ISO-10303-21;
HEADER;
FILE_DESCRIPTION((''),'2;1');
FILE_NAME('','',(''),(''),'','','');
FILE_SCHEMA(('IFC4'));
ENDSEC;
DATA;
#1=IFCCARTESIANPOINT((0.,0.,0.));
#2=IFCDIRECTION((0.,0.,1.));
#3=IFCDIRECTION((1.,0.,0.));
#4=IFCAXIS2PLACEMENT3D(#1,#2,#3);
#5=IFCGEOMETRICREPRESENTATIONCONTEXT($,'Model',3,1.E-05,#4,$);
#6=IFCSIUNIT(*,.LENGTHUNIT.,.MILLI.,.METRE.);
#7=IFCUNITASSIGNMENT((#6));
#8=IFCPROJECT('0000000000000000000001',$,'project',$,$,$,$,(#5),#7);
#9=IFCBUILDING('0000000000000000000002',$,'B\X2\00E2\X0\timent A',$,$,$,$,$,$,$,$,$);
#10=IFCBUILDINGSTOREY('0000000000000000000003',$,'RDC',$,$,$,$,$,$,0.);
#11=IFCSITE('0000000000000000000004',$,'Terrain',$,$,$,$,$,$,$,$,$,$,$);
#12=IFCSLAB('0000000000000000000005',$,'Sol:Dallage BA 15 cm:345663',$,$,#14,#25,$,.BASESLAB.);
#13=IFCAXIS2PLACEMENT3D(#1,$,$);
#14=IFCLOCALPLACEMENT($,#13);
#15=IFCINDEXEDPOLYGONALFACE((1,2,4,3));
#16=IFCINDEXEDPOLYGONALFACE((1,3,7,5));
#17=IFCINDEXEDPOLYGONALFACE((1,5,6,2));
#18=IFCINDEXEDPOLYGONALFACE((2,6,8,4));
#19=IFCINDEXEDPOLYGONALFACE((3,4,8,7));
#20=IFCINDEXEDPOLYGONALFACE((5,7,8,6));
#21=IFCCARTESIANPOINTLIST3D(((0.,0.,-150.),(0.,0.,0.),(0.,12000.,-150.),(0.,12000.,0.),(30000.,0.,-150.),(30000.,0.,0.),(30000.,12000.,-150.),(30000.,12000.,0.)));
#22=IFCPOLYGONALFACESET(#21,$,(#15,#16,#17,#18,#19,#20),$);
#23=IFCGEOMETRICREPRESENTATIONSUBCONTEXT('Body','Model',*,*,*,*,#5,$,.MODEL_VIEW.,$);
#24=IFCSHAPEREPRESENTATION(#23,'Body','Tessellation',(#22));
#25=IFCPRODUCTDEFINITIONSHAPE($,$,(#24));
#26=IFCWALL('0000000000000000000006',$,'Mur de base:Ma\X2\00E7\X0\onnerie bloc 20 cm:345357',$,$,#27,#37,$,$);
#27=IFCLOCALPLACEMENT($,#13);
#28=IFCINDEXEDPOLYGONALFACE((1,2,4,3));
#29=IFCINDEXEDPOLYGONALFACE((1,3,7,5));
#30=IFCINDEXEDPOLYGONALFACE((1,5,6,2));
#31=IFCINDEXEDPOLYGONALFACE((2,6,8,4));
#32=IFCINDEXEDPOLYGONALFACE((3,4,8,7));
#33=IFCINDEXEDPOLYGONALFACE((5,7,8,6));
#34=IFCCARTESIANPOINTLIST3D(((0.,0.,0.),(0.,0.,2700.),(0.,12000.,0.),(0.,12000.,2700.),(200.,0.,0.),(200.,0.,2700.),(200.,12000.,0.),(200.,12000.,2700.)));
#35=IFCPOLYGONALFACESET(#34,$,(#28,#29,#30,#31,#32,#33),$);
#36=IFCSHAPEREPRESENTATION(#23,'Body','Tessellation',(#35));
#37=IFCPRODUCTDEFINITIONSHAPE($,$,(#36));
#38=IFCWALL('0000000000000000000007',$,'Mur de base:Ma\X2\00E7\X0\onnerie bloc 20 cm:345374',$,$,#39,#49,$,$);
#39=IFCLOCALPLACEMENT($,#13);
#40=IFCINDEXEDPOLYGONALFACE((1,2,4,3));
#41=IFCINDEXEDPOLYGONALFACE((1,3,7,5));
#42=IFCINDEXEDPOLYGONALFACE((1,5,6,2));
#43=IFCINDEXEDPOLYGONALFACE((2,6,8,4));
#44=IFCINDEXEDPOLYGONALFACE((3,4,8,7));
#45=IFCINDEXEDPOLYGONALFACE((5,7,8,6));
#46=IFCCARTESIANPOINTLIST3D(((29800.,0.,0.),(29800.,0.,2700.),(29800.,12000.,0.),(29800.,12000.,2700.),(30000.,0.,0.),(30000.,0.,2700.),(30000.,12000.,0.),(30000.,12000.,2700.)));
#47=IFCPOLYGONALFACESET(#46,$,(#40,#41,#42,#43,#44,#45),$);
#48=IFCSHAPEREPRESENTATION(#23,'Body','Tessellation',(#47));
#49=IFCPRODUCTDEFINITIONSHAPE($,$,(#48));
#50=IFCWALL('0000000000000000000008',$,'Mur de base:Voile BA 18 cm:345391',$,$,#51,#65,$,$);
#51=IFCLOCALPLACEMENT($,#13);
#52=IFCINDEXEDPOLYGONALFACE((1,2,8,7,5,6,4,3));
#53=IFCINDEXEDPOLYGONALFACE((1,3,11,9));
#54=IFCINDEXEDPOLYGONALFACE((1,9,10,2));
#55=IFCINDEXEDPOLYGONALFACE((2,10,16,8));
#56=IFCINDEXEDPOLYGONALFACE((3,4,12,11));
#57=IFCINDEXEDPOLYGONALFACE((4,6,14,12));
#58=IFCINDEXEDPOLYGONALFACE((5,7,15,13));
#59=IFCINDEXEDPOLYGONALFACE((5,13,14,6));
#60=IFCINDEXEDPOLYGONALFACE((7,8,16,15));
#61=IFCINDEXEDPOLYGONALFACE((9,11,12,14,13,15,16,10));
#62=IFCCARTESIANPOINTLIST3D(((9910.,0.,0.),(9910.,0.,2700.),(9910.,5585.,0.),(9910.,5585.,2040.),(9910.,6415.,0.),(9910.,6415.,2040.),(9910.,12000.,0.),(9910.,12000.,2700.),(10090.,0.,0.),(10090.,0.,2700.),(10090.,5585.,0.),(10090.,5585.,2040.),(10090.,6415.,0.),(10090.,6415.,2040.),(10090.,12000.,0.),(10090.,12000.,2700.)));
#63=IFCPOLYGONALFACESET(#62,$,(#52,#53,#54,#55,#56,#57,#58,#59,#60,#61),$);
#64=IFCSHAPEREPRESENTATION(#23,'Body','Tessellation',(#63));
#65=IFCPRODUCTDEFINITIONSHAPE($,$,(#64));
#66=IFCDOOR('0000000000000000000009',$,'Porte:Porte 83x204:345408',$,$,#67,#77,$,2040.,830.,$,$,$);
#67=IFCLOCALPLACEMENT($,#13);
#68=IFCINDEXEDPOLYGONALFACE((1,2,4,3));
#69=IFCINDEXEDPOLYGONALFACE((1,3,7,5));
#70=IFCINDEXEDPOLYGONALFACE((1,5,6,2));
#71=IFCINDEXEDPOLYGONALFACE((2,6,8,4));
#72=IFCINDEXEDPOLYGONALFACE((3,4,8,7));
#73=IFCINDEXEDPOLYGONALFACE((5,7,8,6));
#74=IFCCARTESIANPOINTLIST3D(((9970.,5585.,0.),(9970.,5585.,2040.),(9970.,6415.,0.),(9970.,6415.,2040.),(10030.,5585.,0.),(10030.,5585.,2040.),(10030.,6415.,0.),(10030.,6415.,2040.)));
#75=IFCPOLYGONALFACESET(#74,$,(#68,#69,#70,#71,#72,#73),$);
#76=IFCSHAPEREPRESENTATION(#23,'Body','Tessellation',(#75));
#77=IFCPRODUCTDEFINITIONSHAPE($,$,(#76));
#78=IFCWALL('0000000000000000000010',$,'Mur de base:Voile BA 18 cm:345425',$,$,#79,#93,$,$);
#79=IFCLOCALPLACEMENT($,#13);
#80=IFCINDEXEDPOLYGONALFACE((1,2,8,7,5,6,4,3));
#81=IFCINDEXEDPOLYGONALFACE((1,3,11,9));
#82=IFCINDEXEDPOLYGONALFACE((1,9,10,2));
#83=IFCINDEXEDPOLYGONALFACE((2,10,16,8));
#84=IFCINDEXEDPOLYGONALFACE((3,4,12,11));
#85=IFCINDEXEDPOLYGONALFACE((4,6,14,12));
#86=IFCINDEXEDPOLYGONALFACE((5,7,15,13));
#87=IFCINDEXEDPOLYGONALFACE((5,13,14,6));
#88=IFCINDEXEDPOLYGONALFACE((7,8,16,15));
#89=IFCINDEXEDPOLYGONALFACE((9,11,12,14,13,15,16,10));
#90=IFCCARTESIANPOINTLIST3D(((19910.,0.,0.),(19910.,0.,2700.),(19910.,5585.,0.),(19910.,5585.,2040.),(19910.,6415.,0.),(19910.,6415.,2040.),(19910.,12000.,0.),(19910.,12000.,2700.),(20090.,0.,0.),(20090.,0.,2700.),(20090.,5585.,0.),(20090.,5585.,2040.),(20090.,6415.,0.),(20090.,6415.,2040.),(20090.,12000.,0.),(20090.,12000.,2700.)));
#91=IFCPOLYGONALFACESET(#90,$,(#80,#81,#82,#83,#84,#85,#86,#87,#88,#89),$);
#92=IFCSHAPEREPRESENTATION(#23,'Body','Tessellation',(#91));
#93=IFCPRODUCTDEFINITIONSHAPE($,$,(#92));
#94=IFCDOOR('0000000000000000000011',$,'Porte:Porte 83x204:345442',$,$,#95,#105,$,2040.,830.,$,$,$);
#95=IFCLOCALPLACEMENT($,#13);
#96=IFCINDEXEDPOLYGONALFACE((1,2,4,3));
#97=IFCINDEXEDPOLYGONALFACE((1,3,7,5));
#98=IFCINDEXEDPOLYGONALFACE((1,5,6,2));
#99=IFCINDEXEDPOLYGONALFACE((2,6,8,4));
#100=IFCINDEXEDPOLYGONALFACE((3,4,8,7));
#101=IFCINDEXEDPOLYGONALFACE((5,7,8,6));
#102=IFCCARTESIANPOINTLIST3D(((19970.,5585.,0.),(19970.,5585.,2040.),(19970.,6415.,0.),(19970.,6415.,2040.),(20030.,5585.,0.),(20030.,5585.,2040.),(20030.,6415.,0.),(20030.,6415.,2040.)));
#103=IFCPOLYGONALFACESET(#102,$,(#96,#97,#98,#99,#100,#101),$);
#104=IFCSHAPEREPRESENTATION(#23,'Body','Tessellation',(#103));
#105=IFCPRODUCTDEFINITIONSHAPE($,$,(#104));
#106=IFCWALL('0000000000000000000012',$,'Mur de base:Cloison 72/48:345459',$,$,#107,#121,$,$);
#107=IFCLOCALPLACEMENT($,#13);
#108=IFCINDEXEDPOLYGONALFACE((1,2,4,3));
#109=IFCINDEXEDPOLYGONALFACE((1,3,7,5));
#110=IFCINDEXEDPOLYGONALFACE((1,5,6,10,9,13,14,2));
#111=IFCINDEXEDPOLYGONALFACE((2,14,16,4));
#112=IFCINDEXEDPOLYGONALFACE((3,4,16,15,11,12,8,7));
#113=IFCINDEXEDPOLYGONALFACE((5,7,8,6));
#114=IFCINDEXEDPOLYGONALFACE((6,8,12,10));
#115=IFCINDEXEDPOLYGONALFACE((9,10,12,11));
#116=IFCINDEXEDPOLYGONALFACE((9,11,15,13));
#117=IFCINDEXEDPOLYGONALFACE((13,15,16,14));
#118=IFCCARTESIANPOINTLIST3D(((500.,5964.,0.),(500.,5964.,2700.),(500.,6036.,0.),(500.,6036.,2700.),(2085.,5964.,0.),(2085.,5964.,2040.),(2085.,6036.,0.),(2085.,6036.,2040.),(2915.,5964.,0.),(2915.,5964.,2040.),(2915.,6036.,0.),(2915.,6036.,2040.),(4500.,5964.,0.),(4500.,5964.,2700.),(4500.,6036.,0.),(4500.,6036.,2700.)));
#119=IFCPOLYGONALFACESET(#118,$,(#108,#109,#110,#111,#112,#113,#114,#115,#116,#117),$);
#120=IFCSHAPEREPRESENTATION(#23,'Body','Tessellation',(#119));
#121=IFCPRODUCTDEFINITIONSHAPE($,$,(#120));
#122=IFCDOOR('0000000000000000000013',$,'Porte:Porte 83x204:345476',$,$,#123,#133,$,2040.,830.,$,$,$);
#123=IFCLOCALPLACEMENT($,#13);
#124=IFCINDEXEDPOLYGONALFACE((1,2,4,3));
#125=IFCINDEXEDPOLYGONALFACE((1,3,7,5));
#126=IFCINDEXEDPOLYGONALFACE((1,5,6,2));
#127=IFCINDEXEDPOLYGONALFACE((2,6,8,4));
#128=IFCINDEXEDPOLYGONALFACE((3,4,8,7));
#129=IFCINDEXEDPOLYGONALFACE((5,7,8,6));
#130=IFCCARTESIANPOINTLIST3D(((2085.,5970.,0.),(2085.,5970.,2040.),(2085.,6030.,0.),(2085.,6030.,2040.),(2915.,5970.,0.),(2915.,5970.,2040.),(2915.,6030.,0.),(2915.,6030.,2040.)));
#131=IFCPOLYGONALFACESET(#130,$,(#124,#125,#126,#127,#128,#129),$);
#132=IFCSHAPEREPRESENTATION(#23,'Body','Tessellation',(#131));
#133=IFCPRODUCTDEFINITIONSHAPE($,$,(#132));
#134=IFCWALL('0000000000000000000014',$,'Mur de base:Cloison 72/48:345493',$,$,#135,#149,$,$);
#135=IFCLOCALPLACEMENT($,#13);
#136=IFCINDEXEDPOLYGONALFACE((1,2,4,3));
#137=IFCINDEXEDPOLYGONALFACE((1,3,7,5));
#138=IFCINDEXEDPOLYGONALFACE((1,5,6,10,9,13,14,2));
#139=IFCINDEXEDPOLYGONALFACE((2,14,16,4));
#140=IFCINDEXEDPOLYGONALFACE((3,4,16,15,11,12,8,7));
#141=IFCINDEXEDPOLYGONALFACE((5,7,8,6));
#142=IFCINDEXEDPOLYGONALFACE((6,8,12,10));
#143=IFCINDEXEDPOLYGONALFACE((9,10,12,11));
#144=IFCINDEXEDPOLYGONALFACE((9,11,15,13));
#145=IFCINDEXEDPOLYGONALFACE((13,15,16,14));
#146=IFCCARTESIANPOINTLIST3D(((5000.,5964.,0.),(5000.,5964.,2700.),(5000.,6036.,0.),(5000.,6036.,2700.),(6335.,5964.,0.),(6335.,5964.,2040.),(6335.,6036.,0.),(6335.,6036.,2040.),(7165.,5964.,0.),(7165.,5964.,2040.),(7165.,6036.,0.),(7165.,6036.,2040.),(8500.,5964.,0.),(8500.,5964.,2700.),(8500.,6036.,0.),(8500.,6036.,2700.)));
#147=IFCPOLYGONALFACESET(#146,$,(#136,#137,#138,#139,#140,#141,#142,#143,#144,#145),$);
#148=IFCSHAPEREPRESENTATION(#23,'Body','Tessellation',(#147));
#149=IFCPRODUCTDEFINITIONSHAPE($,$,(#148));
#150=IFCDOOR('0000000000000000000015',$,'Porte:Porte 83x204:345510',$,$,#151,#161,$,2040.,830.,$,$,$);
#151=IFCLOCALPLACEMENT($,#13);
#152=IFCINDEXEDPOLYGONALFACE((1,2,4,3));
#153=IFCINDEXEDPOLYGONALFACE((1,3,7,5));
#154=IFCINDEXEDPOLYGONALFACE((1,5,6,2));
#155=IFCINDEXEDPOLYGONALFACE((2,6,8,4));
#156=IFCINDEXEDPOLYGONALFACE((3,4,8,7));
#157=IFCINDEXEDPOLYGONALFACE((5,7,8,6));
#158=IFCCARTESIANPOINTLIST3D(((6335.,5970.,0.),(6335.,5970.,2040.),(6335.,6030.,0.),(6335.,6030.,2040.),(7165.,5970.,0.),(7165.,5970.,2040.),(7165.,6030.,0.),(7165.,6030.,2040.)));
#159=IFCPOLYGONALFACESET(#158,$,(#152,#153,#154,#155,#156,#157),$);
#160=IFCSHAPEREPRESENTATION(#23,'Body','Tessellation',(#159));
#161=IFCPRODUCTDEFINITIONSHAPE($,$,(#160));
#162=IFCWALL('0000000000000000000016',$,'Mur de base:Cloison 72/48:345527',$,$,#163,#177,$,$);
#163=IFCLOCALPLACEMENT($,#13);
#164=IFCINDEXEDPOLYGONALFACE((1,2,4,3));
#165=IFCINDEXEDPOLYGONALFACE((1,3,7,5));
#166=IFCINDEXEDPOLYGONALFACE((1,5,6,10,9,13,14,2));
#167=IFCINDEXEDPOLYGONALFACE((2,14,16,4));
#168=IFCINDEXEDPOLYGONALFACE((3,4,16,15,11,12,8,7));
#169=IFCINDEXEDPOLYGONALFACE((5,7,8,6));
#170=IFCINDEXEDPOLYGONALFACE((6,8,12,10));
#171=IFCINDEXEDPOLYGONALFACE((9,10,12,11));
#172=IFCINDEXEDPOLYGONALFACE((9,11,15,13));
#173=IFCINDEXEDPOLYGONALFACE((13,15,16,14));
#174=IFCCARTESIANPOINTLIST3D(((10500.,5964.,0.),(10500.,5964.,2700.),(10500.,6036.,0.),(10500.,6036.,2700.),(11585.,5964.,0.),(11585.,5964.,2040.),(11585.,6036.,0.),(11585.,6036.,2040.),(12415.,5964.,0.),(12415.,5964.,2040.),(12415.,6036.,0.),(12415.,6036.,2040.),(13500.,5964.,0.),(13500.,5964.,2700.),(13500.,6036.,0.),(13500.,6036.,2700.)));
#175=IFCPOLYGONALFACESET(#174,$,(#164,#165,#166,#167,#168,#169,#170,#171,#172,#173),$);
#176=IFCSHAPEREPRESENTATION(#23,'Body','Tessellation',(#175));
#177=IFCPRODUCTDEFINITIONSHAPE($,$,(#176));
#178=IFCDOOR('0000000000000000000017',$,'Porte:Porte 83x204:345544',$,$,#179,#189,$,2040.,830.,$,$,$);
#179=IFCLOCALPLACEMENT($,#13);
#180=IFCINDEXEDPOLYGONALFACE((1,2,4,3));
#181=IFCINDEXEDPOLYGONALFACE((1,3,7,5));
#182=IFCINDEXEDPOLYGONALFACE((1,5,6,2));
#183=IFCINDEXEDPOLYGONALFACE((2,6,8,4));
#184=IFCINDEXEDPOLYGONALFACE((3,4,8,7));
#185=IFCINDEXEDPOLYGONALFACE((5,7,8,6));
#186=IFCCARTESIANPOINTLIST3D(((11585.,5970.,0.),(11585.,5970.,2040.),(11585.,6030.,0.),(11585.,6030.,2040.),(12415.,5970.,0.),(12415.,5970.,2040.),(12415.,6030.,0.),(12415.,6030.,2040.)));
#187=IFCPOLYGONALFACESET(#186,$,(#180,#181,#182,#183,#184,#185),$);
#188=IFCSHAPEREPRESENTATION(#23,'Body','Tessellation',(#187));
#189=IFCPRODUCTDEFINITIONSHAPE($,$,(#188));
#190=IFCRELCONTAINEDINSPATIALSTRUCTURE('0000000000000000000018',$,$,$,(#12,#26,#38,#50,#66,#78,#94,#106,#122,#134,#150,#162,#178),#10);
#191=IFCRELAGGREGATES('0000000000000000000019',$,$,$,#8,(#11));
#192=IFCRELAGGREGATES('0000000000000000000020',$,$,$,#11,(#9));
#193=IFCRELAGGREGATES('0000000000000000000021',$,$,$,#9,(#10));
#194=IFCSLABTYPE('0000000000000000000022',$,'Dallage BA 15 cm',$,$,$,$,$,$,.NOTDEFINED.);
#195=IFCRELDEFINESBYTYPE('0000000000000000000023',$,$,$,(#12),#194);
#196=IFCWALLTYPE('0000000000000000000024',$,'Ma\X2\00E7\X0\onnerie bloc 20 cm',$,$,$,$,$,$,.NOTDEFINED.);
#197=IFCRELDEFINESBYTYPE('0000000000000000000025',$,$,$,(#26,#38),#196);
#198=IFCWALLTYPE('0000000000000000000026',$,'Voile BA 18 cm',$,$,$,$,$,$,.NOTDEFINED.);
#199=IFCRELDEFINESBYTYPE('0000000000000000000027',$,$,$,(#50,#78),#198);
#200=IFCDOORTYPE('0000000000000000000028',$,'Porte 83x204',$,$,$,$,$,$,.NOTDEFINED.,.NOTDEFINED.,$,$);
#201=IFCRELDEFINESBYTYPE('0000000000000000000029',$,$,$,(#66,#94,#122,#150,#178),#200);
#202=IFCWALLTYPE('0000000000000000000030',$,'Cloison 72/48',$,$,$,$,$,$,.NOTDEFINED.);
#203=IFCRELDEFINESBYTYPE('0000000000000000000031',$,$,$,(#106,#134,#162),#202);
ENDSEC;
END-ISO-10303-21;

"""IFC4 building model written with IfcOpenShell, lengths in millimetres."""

from ifc_helpers import new_model, si_unit, frame, frame_2d, origin_with_axes, place, context, subcontext, project, spatial, rectangle, extrude, type_object, element, fill, save


model = new_model("IFC4")

# Units and contexts
model_context = context("Model", 3, precision=1e-05, world=origin_with_axes())
body_context = subcontext(model_context, "Body", "Model", "MODEL_VIEW")
ifc_project = project(units=[si_unit("LENGTHUNIT", "METRE", prefix="MILLI")], contexts=[model_context])

# Site, building, storey
site = spatial("IfcSite", under=ifc_project, Name="Terrain")
building = spatial("IfcBuilding", under=site, Name="Bâtiment A")
storey = spatial("IfcBuildingStorey", under=building, Name="RDC", Elevation=0.0)

# Slab
slab_type = type_object("IfcSlabType", Name="Dallage BA 15 cm", PredefinedType="NOTDEFINED")
slab_placement = place(None, origin_with_axes())
element("IfcSlab", 1, at=slab_placement, inside=storey, type_object=slab_type, Name="Sol:Dallage BA 15 cm:345663", PredefinedType="BASESLAB", context=body_context, shape_type="SweptSolid", body=[
    extrude(rectangle(XDim=30000.0, YDim=12000.0, at=frame_2d((15000.0, 6000.0))), frame((0.0, 0.0, -150.0), z_axis=(0.0, 0.0, 1.0), x_axis=(1.0, 0.0, 0.0)), (0.0, 0.0, 1.0), 150.0),
])

# Walls
wall_type_1 = type_object("IfcWallType", Name="Maçonnerie bloc 20 cm", PredefinedType="NOTDEFINED")
wall_1_placement = place(None, origin_with_axes())
element("IfcWall", 2, at=wall_1_placement, inside=storey, type_object=wall_type_1, Name="Mur de base:Maçonnerie bloc 20 cm:345357", context=body_context, shape_type="SweptSolid", body=[
    extrude(rectangle(XDim=200.0, YDim=12000.0, at=frame_2d((100.0, 6000.0))), origin_with_axes(), (0.0, 0.0, 1.0), 2700.0),
])
wall_2_placement = place(None, origin_with_axes())
element("IfcWall", 3, at=wall_2_placement, inside=storey, type_object=wall_type_1, Name="Mur de base:Maçonnerie bloc 20 cm:345374", context=body_context, shape_type="SweptSolid", body=[
    extrude(rectangle(XDim=200.0, YDim=12000.0, at=frame_2d((29900.0, 6000.0))), origin_with_axes(), (0.0, 0.0, 1.0), 2700.0),
])

# Walls, openings, doors
wall_type_2 = type_object("IfcWallType", Name="Voile BA 18 cm", PredefinedType="NOTDEFINED")
wall_3_placement = place(None, origin_with_axes())
wall_3 = element("IfcWall", 4, at=wall_3_placement, inside=storey, type_object=wall_type_2, Name="Mur de base:Voile BA 18 cm:345391", context=body_context, shape_type="SweptSolid", body=[
    extrude(rectangle(XDim=180.0, YDim=12000.0, at=frame_2d((10000.0, 6000.0))), origin_with_axes(), (0.0, 0.0, 1.0), 2700.0),
])
opening_1_placement = place(None, origin_with_axes())
opening_1 = element("IfcOpeningElement", 5, at=opening_1_placement, cuts=wall_3, context=body_context, shape_type="SweptSolid", body=[
    extrude(rectangle(XDim=300.0, YDim=830.0, at=frame_2d((10000.0, 6000.0))), origin_with_axes(), (0.0, 0.0, 1.0), 2040.0),
])
door_type = type_object("IfcDoorType", Name="Porte 83x204", OperationType="NOTDEFINED", PredefinedType="NOTDEFINED")
door_1_placement = place(None, origin_with_axes())
door_1 = element("IfcDoor", 6, at=door_1_placement, inside=storey, type_object=door_type, Name="Porte:Porte 83x204:345408", OverallHeight=2040.0, OverallWidth=830.0, context=body_context, shape_type="SweptSolid", body=[
    extrude(rectangle(XDim=60.0, YDim=830.0, at=frame_2d((10000.0, 6000.0))), origin_with_axes(), (0.0, 0.0, 1.0), 2040.0),
])
fill(opening_1, door_1)
wall_4_placement = place(None, origin_with_axes())
wall_4 = element("IfcWall", 7, at=wall_4_placement, inside=storey, type_object=wall_type_2, Name="Mur de base:Voile BA 18 cm:345425", context=body_context, shape_type="SweptSolid", body=[
    extrude(rectangle(XDim=180.0, YDim=12000.0, at=frame_2d((20000.0, 6000.0))), origin_with_axes(), (0.0, 0.0, 1.0), 2700.0),
])
opening_2_placement = place(None, origin_with_axes())
opening_2 = element("IfcOpeningElement", 8, at=opening_2_placement, cuts=wall_4, context=body_context, shape_type="SweptSolid", body=[
    extrude(rectangle(XDim=300.0, YDim=830.0, at=frame_2d((20000.0, 6000.0))), origin_with_axes(), (0.0, 0.0, 1.0), 2040.0),
])
door_2_placement = place(None, origin_with_axes())
door_2 = element("IfcDoor", 9, at=door_2_placement, inside=storey, type_object=door_type, Name="Porte:Porte 83x204:345442", OverallHeight=2040.0, OverallWidth=830.0, context=body_context, shape_type="SweptSolid", body=[
    extrude(rectangle(XDim=60.0, YDim=830.0, at=frame_2d((20000.0, 6000.0))), origin_with_axes(), (0.0, 0.0, 1.0), 2040.0),
])
fill(opening_2, door_2)
wall_type_3 = type_object("IfcWallType", Name="Cloison 72/48", PredefinedType="NOTDEFINED")
wall_5_placement = place(None, origin_with_axes())
wall_5 = element("IfcWall", 10, at=wall_5_placement, inside=storey, type_object=wall_type_3, Name="Mur de base:Cloison 72/48:345459", context=body_context, shape_type="SweptSolid", body=[
    extrude(rectangle(XDim=4000.0, YDim=72.0, at=frame_2d((2500.0, 6000.0))), origin_with_axes(), (0.0, 0.0, 1.0), 2700.0),
])
opening_3_placement = place(None, origin_with_axes())
opening_3 = element("IfcOpeningElement", 11, at=opening_3_placement, cuts=wall_5, context=body_context, shape_type="SweptSolid", body=[
    extrude(rectangle(XDim=830.0, YDim=192.0, at=frame_2d((2500.0, 6000.0))), origin_with_axes(), (0.0, 0.0, 1.0), 2040.0),
])
door_3_placement = place(None, origin_with_axes())
door_3 = element("IfcDoor", 12, at=door_3_placement, inside=storey, type_object=door_type, Name="Porte:Porte 83x204:345476", OverallHeight=2040.0, OverallWidth=830.0, context=body_context, shape_type="SweptSolid", body=[
    extrude(rectangle(XDim=830.0, YDim=60.0, at=frame_2d((2500.0, 6000.0))), origin_with_axes(), (0.0, 0.0, 1.0), 2040.0),
])
fill(opening_3, door_3)
wall_6_placement = place(None, origin_with_axes())
wall_6 = element("IfcWall", 13, at=wall_6_placement, inside=storey, type_object=wall_type_3, Name="Mur de base:Cloison 72/48:345493", context=body_context, shape_type="SweptSolid", body=[
    extrude(rectangle(XDim=3500.0, YDim=72.0, at=frame_2d((6750.0, 6000.0))), origin_with_axes(), (0.0, 0.0, 1.0), 2700.0),
])
opening_4_placement = place(None, origin_with_axes())
opening_4 = element("IfcOpeningElement", 14, at=opening_4_placement, cuts=wall_6, context=body_context, shape_type="SweptSolid", body=[
    extrude(rectangle(XDim=830.0, YDim=192.0, at=frame_2d((6750.0, 6000.0))), origin_with_axes(), (0.0, 0.0, 1.0), 2040.0),
])
door_4_placement = place(None, origin_with_axes())
door_4 = element("IfcDoor", 15, at=door_4_placement, inside=storey, type_object=door_type, Name="Porte:Porte 83x204:345510", OverallHeight=2040.0, OverallWidth=830.0, context=body_context, shape_type="SweptSolid", body=[
    extrude(rectangle(XDim=830.0, YDim=60.0, at=frame_2d((6750.0, 6000.0))), origin_with_axes(), (0.0, 0.0, 1.0), 2040.0),
])
fill(opening_4, door_4)
wall_7_placement = place(None, origin_with_axes())
wall_7 = element("IfcWall", 16, at=wall_7_placement, inside=storey, type_object=wall_type_3, Name="Mur de base:Cloison 72/48:345527", context=body_context, shape_type="SweptSolid", body=[
    extrude(rectangle(XDim=3000.0, YDim=72.0, at=frame_2d((12000.0, 6000.0))), origin_with_axes(), (0.0, 0.0, 1.0), 2700.0),
])
opening_5_placement = place(None, origin_with_axes())
opening_5 = element("IfcOpeningElement", 17, at=opening_5_placement, cuts=wall_7, context=body_context, shape_type="SweptSolid", body=[
    extrude(rectangle(XDim=830.0, YDim=192.0, at=frame_2d((12000.0, 6000.0))), origin_with_axes(), (0.0, 0.0, 1.0), 2040.0),
])
door_5_placement = place(None, origin_with_axes())
door_5 = element("IfcDoor", 18, at=door_5_placement, inside=storey, type_object=door_type, Name="Porte:Porte 83x204:345544", OverallHeight=2040.0, OverallWidth=830.0, context=body_context, shape_type="SweptSolid", body=[
    extrude(rectangle(XDim=830.0, YDim=60.0, at=frame_2d((12000.0, 6000.0))), origin_with_axes(), (0.0, 0.0, 1.0), 2040.0),
])
fill(opening_5, door_5)

save(model, "model.ifc")
